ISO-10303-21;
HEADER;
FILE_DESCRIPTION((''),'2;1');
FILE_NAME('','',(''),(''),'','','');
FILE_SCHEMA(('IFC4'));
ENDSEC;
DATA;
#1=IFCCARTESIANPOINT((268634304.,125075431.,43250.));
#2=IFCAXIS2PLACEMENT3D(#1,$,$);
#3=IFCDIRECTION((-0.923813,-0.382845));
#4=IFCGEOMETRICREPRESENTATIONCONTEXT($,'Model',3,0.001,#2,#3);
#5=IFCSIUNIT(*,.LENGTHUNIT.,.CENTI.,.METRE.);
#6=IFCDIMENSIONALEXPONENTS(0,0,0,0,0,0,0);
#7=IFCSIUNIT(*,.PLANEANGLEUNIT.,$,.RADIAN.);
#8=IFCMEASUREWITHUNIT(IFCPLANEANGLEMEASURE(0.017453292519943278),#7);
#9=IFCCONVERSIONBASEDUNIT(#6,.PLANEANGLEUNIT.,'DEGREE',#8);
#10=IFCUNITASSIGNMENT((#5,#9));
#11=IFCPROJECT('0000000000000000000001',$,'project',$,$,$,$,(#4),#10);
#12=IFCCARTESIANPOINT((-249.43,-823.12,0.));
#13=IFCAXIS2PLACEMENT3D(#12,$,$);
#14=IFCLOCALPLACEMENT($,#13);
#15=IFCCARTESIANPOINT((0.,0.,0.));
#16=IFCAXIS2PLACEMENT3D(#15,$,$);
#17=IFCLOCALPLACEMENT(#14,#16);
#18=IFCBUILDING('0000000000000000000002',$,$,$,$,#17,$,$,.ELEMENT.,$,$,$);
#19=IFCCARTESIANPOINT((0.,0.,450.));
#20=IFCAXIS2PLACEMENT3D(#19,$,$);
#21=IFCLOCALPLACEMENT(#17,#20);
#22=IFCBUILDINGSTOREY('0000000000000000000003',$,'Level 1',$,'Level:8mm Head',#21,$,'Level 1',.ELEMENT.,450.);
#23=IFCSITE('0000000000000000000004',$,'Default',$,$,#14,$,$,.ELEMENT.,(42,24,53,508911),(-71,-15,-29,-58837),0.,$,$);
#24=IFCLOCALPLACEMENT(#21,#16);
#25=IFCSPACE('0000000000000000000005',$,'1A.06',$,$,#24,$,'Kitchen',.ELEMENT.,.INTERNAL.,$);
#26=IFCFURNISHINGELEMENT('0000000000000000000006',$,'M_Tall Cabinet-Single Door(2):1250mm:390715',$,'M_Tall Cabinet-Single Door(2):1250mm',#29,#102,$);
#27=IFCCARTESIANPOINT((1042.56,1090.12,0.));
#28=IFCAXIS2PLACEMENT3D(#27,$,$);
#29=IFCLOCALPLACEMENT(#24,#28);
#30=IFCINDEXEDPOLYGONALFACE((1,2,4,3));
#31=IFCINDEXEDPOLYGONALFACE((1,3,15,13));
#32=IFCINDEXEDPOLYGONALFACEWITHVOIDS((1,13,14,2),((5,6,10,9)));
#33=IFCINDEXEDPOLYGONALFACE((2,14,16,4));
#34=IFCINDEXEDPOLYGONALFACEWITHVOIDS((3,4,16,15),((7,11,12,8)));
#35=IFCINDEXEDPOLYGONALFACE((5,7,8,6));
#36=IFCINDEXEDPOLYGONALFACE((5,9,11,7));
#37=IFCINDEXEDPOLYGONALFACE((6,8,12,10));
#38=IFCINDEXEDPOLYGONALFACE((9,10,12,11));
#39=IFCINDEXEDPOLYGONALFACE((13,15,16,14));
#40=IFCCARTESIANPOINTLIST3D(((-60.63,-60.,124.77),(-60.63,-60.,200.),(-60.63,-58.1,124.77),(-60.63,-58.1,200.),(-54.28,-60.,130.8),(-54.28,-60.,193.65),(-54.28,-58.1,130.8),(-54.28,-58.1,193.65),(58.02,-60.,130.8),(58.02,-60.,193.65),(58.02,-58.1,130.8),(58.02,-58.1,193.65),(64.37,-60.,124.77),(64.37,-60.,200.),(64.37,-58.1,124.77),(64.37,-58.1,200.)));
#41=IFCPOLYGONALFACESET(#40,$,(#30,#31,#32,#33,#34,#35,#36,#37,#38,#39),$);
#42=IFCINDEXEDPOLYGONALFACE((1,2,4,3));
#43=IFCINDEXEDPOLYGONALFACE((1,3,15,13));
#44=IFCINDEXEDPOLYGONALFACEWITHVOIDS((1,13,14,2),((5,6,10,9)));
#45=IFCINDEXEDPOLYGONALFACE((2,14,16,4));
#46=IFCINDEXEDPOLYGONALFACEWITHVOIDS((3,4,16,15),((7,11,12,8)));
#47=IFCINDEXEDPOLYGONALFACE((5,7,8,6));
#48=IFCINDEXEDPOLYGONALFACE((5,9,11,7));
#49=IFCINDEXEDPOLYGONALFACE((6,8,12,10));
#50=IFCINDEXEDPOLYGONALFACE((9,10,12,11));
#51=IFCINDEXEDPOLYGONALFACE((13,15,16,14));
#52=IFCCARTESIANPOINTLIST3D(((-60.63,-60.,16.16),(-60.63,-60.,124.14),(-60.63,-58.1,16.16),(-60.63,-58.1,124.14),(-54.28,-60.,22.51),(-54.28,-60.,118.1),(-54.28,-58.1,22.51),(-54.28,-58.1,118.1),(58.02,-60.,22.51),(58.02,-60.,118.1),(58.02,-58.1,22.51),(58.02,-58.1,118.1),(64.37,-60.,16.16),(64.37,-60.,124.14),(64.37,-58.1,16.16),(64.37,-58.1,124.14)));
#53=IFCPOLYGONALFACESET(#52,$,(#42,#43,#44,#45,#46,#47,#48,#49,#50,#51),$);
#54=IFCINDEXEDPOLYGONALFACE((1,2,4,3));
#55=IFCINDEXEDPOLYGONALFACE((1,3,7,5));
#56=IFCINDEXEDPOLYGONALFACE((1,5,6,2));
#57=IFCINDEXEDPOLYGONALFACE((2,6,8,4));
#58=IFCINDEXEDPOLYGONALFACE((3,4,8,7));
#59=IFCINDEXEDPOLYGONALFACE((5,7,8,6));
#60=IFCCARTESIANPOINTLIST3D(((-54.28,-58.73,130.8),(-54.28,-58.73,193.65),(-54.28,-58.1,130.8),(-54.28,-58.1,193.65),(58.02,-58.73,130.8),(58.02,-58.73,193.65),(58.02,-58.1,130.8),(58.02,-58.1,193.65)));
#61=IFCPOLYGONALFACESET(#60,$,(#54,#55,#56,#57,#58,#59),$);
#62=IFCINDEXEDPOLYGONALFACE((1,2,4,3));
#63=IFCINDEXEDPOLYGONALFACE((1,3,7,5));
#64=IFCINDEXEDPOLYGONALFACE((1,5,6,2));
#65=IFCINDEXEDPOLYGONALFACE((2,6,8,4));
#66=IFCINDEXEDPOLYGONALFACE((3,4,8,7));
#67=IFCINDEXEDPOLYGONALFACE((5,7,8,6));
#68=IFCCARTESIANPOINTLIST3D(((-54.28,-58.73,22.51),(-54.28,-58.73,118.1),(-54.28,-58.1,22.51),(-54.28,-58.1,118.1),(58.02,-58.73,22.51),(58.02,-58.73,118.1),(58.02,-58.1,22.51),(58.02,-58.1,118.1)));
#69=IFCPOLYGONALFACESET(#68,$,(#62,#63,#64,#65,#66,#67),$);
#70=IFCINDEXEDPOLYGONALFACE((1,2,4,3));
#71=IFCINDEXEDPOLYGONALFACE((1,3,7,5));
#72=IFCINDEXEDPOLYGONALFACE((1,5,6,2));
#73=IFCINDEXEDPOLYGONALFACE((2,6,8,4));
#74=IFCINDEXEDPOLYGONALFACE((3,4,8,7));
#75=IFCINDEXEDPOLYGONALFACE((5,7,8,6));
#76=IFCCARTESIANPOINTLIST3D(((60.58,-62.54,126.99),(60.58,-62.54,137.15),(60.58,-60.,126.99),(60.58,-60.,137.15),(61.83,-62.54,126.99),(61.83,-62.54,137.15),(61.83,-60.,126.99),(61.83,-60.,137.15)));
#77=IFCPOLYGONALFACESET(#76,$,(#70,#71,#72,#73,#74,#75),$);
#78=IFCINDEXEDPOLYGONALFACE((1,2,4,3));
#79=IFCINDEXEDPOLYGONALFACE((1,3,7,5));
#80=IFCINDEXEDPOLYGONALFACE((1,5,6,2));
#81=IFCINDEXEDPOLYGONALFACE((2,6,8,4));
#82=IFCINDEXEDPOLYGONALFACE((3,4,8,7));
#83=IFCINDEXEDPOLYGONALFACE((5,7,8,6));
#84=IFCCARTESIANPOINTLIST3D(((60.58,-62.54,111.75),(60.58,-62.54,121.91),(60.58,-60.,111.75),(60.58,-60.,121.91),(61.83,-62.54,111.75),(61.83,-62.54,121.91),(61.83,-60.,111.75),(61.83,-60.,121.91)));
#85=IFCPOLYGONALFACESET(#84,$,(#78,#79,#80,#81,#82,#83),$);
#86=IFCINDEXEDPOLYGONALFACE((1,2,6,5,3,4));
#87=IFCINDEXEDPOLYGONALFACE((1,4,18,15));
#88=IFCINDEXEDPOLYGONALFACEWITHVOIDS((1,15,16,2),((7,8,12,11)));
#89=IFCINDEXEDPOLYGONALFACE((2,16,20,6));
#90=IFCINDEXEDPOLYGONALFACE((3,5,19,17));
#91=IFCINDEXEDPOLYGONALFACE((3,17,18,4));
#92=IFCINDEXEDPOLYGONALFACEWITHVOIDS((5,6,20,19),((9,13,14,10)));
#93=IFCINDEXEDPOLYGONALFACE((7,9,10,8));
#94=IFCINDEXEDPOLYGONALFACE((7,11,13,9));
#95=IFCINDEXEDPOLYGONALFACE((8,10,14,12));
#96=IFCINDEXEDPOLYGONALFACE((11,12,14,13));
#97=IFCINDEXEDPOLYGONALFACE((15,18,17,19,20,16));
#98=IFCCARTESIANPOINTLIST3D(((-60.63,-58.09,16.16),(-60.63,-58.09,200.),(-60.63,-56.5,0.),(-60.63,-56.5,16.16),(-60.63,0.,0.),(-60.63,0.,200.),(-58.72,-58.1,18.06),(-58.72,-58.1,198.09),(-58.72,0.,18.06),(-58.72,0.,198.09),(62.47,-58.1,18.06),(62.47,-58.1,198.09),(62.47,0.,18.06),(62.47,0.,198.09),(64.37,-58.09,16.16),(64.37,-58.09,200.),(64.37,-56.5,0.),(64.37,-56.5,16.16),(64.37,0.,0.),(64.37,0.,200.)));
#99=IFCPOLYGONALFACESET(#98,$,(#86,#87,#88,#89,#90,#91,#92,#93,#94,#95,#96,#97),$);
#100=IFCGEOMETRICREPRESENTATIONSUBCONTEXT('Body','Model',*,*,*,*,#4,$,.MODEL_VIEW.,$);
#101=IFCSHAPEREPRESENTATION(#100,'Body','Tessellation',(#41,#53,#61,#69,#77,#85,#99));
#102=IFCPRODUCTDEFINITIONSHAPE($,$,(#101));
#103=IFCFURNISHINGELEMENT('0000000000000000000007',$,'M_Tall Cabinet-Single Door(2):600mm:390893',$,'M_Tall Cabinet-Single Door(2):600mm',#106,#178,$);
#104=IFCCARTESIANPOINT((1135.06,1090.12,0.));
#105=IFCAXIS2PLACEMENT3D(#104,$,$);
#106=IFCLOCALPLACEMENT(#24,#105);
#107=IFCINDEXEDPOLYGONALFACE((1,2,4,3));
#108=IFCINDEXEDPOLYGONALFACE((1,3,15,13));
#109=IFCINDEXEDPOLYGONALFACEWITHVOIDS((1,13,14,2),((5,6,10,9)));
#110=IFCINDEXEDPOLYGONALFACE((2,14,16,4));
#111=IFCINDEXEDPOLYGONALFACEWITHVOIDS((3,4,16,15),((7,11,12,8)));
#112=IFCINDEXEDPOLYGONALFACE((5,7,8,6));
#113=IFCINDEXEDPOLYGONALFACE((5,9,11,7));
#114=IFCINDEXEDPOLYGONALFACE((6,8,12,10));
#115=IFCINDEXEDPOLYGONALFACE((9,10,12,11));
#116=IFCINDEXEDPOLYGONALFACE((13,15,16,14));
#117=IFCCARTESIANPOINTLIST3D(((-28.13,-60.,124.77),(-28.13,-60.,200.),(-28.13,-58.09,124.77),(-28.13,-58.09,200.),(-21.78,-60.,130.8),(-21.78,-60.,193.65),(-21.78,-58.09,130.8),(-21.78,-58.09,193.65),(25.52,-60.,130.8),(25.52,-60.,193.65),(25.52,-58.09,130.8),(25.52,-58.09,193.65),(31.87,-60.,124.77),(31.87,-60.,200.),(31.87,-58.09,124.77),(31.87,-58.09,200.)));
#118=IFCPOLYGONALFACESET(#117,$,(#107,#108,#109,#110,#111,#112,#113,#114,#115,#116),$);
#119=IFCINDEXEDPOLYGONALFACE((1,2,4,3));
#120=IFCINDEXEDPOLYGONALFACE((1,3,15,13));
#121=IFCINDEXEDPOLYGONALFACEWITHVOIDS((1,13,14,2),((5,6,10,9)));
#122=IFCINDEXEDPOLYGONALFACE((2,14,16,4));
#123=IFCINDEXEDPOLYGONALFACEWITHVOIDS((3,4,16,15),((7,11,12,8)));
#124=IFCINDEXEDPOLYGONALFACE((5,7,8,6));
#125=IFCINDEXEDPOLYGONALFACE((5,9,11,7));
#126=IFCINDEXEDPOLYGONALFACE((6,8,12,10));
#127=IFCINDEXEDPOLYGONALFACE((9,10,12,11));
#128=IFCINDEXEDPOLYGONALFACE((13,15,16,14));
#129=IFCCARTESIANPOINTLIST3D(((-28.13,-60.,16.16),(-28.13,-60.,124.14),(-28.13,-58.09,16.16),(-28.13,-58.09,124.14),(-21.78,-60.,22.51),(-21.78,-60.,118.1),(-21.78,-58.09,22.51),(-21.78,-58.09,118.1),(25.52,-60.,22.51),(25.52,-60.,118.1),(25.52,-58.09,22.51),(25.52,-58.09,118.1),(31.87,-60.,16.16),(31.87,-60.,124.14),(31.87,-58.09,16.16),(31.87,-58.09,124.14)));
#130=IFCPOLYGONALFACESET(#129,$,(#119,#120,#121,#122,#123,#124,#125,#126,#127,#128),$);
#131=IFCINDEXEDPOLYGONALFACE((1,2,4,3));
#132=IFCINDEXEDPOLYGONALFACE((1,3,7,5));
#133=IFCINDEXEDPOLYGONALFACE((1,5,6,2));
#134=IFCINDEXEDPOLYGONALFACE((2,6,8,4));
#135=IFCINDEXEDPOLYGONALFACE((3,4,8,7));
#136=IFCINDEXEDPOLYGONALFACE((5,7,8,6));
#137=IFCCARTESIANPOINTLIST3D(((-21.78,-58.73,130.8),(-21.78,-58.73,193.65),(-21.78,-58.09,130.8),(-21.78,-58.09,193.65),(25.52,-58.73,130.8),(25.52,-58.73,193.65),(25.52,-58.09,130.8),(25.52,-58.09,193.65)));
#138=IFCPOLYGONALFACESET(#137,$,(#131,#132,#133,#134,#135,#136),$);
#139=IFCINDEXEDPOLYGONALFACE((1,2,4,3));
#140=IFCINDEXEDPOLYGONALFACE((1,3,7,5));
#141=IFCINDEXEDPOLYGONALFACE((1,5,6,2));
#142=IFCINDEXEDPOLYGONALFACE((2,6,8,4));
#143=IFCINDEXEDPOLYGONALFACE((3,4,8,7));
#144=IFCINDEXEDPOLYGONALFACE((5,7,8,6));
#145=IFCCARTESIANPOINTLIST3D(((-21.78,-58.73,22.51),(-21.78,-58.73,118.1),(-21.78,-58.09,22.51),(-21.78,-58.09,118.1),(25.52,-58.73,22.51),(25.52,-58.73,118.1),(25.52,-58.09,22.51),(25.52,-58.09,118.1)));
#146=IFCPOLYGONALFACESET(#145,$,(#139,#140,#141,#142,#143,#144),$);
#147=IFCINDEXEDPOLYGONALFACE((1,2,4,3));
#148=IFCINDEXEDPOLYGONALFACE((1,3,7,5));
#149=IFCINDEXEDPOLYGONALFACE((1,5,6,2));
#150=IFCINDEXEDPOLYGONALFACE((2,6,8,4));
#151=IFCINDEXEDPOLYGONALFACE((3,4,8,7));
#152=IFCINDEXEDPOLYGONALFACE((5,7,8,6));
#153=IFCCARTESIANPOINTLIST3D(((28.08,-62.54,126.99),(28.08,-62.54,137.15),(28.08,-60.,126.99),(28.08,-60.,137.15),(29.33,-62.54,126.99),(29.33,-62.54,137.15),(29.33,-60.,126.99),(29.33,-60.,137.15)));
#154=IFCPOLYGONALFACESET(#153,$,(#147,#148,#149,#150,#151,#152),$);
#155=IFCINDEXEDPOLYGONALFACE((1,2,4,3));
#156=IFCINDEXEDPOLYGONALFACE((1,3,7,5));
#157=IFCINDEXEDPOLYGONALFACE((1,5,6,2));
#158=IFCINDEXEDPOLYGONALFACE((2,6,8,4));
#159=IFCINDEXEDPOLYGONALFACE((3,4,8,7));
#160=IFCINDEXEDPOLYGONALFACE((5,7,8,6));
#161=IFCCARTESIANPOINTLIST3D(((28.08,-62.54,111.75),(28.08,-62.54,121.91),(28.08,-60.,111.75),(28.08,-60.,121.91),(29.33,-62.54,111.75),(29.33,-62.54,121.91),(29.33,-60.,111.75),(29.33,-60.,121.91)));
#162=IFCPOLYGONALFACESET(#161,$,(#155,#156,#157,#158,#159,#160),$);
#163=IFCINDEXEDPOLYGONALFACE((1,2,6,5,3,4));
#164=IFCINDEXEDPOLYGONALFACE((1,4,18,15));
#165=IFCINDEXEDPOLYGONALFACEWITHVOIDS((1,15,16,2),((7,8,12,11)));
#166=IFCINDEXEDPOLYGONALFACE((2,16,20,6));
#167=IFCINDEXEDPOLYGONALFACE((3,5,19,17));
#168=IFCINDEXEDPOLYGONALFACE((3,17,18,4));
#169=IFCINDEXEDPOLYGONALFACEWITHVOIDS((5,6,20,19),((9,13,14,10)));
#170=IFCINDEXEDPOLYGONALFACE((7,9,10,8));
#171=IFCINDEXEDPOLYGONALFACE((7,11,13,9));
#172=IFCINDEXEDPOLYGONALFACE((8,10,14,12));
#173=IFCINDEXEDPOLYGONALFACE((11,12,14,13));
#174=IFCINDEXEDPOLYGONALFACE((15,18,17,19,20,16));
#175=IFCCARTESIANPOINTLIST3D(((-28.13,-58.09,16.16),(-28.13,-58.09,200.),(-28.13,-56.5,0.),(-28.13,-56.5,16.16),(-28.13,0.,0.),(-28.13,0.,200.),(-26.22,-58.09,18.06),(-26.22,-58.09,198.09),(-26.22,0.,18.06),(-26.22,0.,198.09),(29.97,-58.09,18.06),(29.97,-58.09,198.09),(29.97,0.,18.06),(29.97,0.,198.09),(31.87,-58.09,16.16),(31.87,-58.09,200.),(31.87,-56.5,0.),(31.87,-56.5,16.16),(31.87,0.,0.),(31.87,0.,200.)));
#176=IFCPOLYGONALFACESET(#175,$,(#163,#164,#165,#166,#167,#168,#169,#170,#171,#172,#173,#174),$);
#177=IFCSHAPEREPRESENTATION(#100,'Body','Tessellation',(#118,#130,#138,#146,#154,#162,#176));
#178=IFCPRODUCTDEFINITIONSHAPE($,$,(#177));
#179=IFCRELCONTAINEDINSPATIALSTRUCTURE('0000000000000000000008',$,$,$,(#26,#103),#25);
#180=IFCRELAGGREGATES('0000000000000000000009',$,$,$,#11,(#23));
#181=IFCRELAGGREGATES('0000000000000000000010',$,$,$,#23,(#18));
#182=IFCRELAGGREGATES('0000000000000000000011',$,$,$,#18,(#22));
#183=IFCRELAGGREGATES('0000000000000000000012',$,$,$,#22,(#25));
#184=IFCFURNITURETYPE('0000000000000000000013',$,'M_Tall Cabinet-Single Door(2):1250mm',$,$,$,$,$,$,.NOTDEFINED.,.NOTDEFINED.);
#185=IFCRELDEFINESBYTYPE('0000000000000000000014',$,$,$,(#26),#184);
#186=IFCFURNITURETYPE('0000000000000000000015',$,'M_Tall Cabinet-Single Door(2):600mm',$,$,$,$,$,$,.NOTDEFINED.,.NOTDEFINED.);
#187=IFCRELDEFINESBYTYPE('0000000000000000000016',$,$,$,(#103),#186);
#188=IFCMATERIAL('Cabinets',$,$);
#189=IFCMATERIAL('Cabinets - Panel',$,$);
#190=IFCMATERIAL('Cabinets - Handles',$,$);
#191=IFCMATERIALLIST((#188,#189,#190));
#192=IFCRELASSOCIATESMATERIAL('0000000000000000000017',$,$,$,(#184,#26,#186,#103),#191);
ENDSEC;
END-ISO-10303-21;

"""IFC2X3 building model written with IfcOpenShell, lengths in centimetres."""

from ifc_helpers import new_model, entity, si_unit, converted_unit, direction, frame, frame_2d, origin, origin_2d_with_axis, place, context, subcontext, project, spatial, polyline, rectangle, outline, extrude, source, transform, mapped, material, material_list, type_object, type_shapes, element, save


model = new_model("IFC2X3")

# Units and contexts
model_context = context("Model", 3, precision=0.001, world=frame((268634304.0, 125075431.0, 43250.0)), true_north=direction((-0.923813, -0.382845)))
body_context = subcontext(model_context, "Body", "Model", "MODEL_VIEW")
ifc_project = project(units=[si_unit("LENGTHUNIT", "METRE", prefix="CENTI"), converted_unit("PLANEANGLEUNIT", "DEGREE", entity("IfcPlaneAngleMeasure", 0.017453292519943278), si_unit("PLANEANGLEUNIT", "RADIAN"), dimensions=[0, 0, 0, 0, 0, 0, 0])], contexts=[model_context])

# Site, building, storey
site_placement = place(None, frame((-249.43, -823.12, 0.0)))
site = spatial("IfcSite", under=ifc_project, at=site_placement, Name="Default", CompositionType="ELEMENT", RefLatitude=(42, 24, 53, 508911), RefLongitude=(-71, -15, -29, -58837), RefElevation=0.0)
building_placement = place(site_placement, origin())
building = spatial("IfcBuilding", under=site, at=building_placement, CompositionType="ELEMENT")
storey_placement = place(building_placement, frame((0.0, 0.0, 450.0)))
storey = spatial("IfcBuildingStorey", under=building, at=storey_placement, Name="Level 1", ObjectType="Level:8mm Head", LongName="Level 1", CompositionType="ELEMENT", Elevation=450.0)

# Shared definitions
space_1_placement = place(storey_placement, origin())
space_1 = spatial("IfcSpace", under=storey, at=space_1_placement, Name="1A.06", LongName="Kitchen", CompositionType="ELEMENT", InteriorOrExteriorSpace="INTERNAL")

# Furnishing elements, openings
ifc_material_1 = material(Name="Cabinets")
ifc_material_2 = material(Name="Cabinets - Panel")
ifc_material_3 = material(Name="Cabinets - Handles")
ifc_material_list_1 = material_list([ifc_material_1, ifc_material_2, ifc_material_3])
furniture_type_1 = type_object("IfcFurnitureType", Name="M_Tall Cabinet-Single Door(2):1250mm", AssemblyPlace="NOTDEFINED", material=ifc_material_list_1)
shared_shape_1 = source(origin(), body_context, "Body", "SweptSolid", [
    extrude(rectangle(XDim=1.91, YDim=121.19, at=origin_2d_with_axis()), frame((1.87, -0.95, 18.06), z_axis=(0.0, 0.0, 1.0), x_axis=(0.0, 1.0, 0.0)), (0.0, 0.0, 1.0), 180.03),
    extrude(outline(polyline([(-37.61, -62.5), (37.61, -62.5), (37.61, 62.5), (-37.61, 62.5), (-37.61, -62.5)]), holes=[polyline([(-31.26, -56.15), (-31.26, 56.15), (31.58, 56.15), (31.58, -56.15), (-31.26, -56.15)])]), frame((1.87, -60.0, 162.39), z_axis=(0.0, 1.0, 0.0), x_axis=(0.0, 0.0, -1.0)), (0.0, 0.0, 1.0), 1.91),
    extrude(outline(polyline([(-62.5, -53.99), (62.5, -53.99), (62.5, 53.99), (-62.5, 53.99), (-62.5, -53.99)]), holes=[polyline([(-56.15, 47.96), (56.15, 47.96), (56.15, -47.64), (-56.15, -47.64), (-56.15, 47.96)])]), frame((1.87, -60.0, 70.15), z_axis=(0.0, 1.0, 0.0), x_axis=(-1.0, 0.0, 0.0)), (0.0, 0.0, 1.0), 1.91),
    extrude(rectangle(XDim=0.63, YDim=112.3, at=frame_2d((0.0, 0.0), x_axis=(1.0, 0.0))), frame((1.87, -58.41, 130.8), z_axis=(0.0, 0.0, 1.0), x_axis=(0.0, 1.0, 0.0)), (0.0, 0.0, 1.0), 62.85),
    extrude(rectangle(XDim=0.63, YDim=112.3, at=frame_2d((0.0, 0.0), x_axis=(1.0, 0.0))), frame((1.87, -58.41, 22.51), z_axis=(0.0, 0.0, 1.0), x_axis=(0.0, 1.0, 0.0)), (0.0, 0.0, 1.0), 95.6),
    extrude(rectangle(XDim=2.54, YDim=1.25, at=frame_2d((0.0, 0.0), x_axis=(1.0, 0.0))), frame((61.21, -61.27, 126.99), z_axis=(0.0, 0.0, 1.0), x_axis=(0.0, 1.0, 0.0)), (0.0, 0.0, 1.0), 10.16),
    extrude(rectangle(XDim=2.54, YDim=1.25, at=frame_2d((0.0, 0.0), x_axis=(1.0, 0.0))), frame((61.21, -61.27, 111.75), z_axis=(0.0, 0.0, 1.0), x_axis=(0.0, 1.0, 0.0)), (0.0, 0.0, 1.0), 10.16),
    extrude(outline(polyline([(-19.9, 55.89), (-19.9, -127.95), (38.2, -127.95), (38.2, 72.05), (-18.3, 72.05), (-18.3, 55.89), (-19.9, 55.89)])), frame((-60.63, -38.2, 72.05), z_axis=(-1.0, 0.0, 0.0), x_axis=(0.0, 1.0, 0.0)), (0.0, 0.0, -1.0), 125.0),
])
type_shapes(furniture_type_1, [shared_shape_1])
furnishing_1_placement = place(space_1_placement, frame((1042.56, 1090.12, 0.0)))
furnishing_1 = element("IfcFurnishingElement", 1, at=furnishing_1_placement, inside=space_1, type_object=furniture_type_1, material=ifc_material_list_1, Name="M_Tall Cabinet-Single Door(2):1250mm:390715", ObjectType="M_Tall Cabinet-Single Door(2):1250mm", context=body_context, shape_type="MappedRepresentation", body=[
    mapped(shared_shape_1, transform((0.0, 0.0, 0.0), scale=1.0)),
])
opening_1_placement = place(storey_placement, frame((1042.56, 1090.12, 450.0)))
element("IfcOpeningElement", 2, at=opening_1_placement, cuts=furnishing_1, ObjectType="Opening", context=body_context, shape_type="SweptSolid", body=[
    extrude(rectangle(XDim=180.03, YDim=121.19, at=frame_2d((0.0, 0.0), x_axis=(0.0, 1.0))), frame((1.87, 0.0, -341.92), z_axis=(0.0, -1.0, 0.0), x_axis=(-1.0, 0.0, 0.0)), (0.0, 0.0, 1.0), 58.09),
])
furniture_type_2 = type_object("IfcFurnitureType", Name="M_Tall Cabinet-Single Door(2):600mm", AssemblyPlace="NOTDEFINED", material=ifc_material_list_1)
shared_shape_2 = source(origin(), body_context, "Body", "SweptSolid", [
    extrude(rectangle(XDim=1.91, YDim=56.19, at=origin_2d_with_axis()), frame((1.87, -0.95, 18.06), z_axis=(0.0, 0.0, 1.0), x_axis=(0.0, 1.0, 0.0)), (0.0, 0.0, 1.0), 180.03),
    extrude(outline(polyline([(-37.61, -30.0), (37.61, -30.0), (37.61, 30.0), (-37.61, 30.0), (-37.61, -30.0)]), holes=[polyline([(-31.26, -23.65), (-31.26, 23.65), (31.58, 23.65), (31.58, -23.65), (-31.26, -23.65)])]), frame((1.87, -60.0, 162.39), z_axis=(0.0, 1.0, 0.0), x_axis=(0.0, 0.0, -1.0)), (0.0, 0.0, 1.0), 1.91),
    extrude(outline(polyline([(-30.0, -53.99), (30.0, -53.99), (30.0, 53.99), (-30.0, 53.99), (-30.0, -53.99)]), holes=[polyline([(-23.65, 47.96), (23.65, 47.96), (23.65, -47.64), (-23.65, -47.64), (-23.65, 47.96)])]), frame((1.87, -60.0, 70.15), z_axis=(0.0, 1.0, 0.0), x_axis=(-1.0, 0.0, 0.0)), (0.0, 0.0, 1.0), 1.91),
    extrude(rectangle(XDim=0.63, YDim=47.3, at=origin_2d_with_axis()), frame((1.87, -58.41, 130.8), z_axis=(0.0, 0.0, 1.0), x_axis=(0.0, 1.0, 0.0)), (0.0, 0.0, 1.0), 62.85),
    extrude(rectangle(XDim=0.63, YDim=47.3, at=origin_2d_with_axis()), frame((1.87, -58.41, 22.51), z_axis=(0.0, 0.0, 1.0), x_axis=(0.0, 1.0, 0.0)), (0.0, 0.0, 1.0), 95.6),
    extrude(rectangle(XDim=2.54, YDim=1.25, at=frame_2d((0.0, 0.0), x_axis=(1.0, 0.0))), frame((28.71, -61.27, 126.99), z_axis=(0.0, 0.0, 1.0), x_axis=(0.0, 1.0, 0.0)), (0.0, 0.0, 1.0), 10.16),
    extrude(rectangle(XDim=2.54, YDim=1.25, at=frame_2d((0.0, 0.0), x_axis=(1.0, 0.0))), frame((28.71, -61.27, 111.75), z_axis=(0.0, 0.0, 1.0), x_axis=(0.0, 1.0, 0.0)), (0.0, 0.0, 1.0), 10.16),
    extrude(outline(polyline([(-19.9, 55.89), (-19.9, -127.95), (38.2, -127.95), (38.2, 72.05), (-18.3, 72.05), (-18.3, 55.89), (-19.9, 55.89)])), frame((-28.13, -38.2, 72.05), z_axis=(-1.0, 0.0, 0.0), x_axis=(0.0, 1.0, 0.0)), (0.0, 0.0, -1.0), 60.0),
])
type_shapes(furniture_type_2, [shared_shape_2])
furnishing_2_placement = place(space_1_placement, frame((1135.06, 1090.12, 0.0)))
furnishing_2 = element("IfcFurnishingElement", 3, at=furnishing_2_placement, inside=space_1, type_object=furniture_type_2, material=ifc_material_list_1, Name="M_Tall Cabinet-Single Door(2):600mm:390893", ObjectType="M_Tall Cabinet-Single Door(2):600mm", context=body_context, shape_type="MappedRepresentation", body=[
    mapped(shared_shape_2, transform((0.0, 0.0, 0.0), scale=1.0)),
])
opening_2_placement = place(storey_placement, frame((1135.06, 1090.12, 450.0)))
element("IfcOpeningElement", 4, at=opening_2_placement, cuts=furnishing_2, ObjectType="Opening", context=body_context, shape_type="SweptSolid", body=[
    extrude(rectangle(XDim=180.03, YDim=56.19, at=frame_2d((0.0, 0.0), x_axis=(0.0, 1.0))), frame((1.87, 0.0, -341.92), z_axis=(0.0, -1.0, 0.0), x_axis=(-1.0, 0.0, 0.0)), (0.0, 0.0, 1.0), 58.09),
])

save(model, "model.ifc")
